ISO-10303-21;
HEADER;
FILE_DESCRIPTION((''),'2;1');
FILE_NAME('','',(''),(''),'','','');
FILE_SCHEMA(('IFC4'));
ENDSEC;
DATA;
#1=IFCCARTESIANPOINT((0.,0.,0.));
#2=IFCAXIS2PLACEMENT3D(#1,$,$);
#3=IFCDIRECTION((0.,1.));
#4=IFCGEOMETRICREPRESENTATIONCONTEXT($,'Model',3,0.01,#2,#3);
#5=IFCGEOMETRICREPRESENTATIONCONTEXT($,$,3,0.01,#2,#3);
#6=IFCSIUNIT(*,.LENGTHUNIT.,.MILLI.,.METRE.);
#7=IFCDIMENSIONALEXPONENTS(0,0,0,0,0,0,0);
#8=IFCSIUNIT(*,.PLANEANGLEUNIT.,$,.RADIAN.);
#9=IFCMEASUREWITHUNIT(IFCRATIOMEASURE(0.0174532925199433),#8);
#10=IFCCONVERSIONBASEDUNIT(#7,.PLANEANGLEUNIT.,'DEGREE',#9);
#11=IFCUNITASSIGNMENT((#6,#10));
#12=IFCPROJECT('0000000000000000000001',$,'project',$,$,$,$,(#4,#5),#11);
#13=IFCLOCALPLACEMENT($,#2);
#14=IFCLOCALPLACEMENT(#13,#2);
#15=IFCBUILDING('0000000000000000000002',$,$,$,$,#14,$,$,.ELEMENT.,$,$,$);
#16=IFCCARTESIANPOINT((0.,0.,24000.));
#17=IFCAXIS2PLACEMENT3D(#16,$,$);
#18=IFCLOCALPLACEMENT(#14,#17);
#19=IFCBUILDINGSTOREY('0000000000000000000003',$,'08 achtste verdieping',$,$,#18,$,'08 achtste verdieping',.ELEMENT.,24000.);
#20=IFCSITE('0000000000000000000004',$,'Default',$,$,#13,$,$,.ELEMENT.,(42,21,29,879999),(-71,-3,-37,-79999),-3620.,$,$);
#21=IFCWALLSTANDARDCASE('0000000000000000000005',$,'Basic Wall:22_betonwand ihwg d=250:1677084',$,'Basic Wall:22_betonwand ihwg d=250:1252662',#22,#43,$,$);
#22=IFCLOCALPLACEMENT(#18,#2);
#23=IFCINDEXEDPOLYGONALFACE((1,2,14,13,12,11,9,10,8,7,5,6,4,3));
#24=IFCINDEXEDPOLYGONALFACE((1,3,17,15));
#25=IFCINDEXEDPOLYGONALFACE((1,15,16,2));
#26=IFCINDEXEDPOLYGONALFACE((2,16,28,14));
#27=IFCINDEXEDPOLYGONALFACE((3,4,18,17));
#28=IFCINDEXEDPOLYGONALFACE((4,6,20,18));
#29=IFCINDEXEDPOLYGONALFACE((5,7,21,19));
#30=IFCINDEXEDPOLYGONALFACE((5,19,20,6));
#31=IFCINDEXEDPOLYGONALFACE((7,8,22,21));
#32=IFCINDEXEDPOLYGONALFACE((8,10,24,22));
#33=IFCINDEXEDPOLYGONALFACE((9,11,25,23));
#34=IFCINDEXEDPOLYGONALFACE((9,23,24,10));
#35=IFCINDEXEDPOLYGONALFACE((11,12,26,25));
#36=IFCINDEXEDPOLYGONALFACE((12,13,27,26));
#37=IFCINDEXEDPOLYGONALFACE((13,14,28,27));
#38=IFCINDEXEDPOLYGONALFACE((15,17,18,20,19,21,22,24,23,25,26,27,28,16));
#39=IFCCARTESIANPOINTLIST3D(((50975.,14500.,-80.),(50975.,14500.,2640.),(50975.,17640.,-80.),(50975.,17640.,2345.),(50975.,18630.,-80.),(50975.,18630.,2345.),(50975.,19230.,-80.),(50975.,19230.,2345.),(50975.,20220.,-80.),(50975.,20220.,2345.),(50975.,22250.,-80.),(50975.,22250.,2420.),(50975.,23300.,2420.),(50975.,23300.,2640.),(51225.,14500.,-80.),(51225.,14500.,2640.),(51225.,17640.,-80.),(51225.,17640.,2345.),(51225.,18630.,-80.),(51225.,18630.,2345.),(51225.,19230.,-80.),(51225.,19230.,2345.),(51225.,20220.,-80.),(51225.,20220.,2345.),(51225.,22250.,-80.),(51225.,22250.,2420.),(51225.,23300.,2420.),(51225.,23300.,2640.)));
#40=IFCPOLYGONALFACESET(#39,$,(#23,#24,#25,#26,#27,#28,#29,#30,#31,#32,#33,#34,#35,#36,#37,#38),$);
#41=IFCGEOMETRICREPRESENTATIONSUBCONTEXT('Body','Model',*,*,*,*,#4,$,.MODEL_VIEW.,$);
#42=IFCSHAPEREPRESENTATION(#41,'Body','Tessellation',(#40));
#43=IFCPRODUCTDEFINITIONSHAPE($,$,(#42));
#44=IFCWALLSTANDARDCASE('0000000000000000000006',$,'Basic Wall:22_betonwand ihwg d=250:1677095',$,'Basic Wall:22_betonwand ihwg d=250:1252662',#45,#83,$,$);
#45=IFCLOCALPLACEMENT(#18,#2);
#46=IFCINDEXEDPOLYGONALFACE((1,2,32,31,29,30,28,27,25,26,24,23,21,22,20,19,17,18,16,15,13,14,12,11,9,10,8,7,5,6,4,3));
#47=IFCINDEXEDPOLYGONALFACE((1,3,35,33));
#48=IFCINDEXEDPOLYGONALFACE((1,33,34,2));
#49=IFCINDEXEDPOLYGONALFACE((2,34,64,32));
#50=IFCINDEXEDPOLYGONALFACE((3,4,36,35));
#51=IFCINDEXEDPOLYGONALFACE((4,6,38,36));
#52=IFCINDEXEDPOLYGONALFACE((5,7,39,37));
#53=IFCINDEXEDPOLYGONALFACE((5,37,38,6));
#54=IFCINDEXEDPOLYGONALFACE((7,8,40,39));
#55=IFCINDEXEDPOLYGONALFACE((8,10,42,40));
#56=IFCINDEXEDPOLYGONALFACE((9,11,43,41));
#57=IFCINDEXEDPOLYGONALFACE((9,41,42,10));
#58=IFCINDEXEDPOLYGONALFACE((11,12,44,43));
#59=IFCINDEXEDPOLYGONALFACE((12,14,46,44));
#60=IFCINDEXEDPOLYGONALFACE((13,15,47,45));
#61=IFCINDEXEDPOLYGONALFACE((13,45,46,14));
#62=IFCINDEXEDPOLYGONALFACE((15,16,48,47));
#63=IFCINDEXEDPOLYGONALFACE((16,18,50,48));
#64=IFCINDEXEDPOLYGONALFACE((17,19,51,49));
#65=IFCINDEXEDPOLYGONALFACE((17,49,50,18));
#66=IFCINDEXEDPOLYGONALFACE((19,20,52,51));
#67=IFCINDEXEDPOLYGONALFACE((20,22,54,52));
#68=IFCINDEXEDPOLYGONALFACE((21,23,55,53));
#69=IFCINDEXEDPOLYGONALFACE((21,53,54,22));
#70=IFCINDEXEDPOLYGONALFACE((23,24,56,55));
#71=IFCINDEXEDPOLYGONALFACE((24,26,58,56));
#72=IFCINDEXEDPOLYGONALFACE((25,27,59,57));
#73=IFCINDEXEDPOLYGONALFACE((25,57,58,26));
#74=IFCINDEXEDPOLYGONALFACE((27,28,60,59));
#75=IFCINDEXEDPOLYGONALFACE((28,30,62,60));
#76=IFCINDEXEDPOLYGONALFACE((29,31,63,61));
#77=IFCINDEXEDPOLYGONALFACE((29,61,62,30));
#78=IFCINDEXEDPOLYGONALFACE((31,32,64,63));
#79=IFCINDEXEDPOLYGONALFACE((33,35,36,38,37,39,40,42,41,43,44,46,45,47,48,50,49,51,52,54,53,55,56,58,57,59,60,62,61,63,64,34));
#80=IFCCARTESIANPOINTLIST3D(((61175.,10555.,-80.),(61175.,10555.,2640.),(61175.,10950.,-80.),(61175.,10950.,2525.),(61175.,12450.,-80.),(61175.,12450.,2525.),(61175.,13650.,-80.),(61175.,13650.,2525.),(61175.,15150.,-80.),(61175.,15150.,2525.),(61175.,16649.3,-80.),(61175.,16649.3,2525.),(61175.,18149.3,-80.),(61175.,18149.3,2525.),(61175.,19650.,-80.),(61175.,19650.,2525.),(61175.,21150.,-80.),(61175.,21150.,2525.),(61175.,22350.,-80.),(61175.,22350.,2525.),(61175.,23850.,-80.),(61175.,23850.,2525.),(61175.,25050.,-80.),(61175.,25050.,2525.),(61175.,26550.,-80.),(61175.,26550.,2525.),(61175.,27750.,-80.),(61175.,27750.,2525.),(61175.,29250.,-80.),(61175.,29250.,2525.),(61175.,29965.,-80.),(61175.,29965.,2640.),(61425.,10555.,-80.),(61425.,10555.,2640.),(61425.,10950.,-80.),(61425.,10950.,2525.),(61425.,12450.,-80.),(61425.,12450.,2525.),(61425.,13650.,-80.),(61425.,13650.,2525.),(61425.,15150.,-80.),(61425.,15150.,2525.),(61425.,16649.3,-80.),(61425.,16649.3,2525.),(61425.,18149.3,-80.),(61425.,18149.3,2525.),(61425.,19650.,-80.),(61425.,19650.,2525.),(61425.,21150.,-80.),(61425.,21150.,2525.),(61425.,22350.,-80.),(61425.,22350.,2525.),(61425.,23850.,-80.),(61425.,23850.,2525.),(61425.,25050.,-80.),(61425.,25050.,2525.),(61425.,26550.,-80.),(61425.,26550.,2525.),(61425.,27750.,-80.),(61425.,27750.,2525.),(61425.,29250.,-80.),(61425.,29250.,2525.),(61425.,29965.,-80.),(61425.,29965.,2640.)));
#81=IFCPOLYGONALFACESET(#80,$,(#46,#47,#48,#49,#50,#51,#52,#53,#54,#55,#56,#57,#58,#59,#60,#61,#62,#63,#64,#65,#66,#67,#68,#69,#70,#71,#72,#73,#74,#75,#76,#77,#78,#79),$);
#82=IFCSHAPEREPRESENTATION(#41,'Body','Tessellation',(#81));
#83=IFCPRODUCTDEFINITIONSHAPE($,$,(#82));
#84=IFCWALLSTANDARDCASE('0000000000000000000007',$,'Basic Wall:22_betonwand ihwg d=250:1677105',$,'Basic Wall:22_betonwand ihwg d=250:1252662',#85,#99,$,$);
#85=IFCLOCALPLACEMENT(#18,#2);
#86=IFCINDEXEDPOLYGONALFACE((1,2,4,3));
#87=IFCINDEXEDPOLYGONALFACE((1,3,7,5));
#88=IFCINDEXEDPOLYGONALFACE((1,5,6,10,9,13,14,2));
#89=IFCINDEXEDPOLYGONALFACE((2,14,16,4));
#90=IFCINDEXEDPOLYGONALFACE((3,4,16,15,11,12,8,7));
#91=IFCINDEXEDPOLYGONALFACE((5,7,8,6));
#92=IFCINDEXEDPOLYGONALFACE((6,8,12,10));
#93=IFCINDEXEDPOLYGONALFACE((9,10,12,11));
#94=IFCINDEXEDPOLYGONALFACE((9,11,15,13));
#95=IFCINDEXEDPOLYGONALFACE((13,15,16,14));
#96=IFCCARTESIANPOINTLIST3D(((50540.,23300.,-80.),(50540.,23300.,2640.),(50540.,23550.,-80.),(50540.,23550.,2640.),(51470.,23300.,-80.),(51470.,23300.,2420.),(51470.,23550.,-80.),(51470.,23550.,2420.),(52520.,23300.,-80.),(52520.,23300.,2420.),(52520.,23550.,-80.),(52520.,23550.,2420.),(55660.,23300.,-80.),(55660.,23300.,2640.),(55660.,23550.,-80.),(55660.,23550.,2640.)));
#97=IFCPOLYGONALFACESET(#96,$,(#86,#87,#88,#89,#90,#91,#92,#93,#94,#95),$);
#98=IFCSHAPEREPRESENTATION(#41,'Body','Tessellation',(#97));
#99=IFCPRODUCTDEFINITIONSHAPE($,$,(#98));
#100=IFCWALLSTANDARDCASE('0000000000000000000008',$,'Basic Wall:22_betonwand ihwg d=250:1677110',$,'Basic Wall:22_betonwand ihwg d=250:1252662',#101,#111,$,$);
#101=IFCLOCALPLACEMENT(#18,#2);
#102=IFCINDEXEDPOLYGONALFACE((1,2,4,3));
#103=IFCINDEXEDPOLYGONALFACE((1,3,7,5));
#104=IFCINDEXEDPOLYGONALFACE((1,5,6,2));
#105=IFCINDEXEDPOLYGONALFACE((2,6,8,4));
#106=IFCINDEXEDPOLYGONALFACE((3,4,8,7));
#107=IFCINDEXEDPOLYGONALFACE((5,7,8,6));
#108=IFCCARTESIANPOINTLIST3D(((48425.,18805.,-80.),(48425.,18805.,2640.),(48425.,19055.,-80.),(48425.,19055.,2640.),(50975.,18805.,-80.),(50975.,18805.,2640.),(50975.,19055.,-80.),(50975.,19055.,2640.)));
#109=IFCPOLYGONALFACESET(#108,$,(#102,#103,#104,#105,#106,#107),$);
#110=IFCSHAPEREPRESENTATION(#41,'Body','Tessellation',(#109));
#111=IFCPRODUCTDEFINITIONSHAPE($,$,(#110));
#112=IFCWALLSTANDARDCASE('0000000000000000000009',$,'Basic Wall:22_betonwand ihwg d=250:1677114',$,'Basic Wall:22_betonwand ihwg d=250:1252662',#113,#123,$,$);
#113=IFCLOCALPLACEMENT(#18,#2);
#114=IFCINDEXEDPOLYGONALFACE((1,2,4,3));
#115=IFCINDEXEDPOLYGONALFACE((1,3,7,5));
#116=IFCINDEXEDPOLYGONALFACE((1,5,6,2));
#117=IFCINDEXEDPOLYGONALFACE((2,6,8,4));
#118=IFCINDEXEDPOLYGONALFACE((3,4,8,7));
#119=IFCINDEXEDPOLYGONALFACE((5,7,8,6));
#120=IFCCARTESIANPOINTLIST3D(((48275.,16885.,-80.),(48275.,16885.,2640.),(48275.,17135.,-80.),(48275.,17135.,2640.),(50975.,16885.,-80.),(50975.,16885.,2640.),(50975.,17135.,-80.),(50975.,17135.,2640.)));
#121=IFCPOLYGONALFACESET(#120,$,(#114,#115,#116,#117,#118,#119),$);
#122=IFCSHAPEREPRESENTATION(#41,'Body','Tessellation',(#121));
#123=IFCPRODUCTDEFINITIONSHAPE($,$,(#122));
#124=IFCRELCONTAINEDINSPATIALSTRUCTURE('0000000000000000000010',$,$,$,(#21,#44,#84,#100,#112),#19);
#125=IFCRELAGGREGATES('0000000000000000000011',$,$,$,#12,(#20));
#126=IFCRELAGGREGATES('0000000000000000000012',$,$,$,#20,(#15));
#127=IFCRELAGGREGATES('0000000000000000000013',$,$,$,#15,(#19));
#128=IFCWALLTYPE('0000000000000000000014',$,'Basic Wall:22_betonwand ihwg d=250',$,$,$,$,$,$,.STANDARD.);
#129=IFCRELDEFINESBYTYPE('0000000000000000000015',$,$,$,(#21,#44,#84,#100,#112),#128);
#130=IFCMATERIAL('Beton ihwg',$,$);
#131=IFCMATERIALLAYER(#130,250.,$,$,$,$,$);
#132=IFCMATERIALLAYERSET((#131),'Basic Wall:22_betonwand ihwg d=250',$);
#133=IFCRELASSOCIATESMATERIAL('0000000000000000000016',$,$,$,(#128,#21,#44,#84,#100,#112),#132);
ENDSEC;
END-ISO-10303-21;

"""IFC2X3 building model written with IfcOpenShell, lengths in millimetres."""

from ifc_helpers import new_model, entity, si_unit, converted_unit, direction, frame, frame_2d, origin, place, context, subcontext, project, spatial, rectangle, extrude, material, layer, layer_set, layer_usage, type_object, element, save


model = new_model("IFC2X3")

# Units and contexts
model_context = context("Model", 3, precision=0.01, world=origin(), true_north=direction((0.0, 1.0)))
context_of_model = context(None, 3, precision=0.01, world=origin(), true_north=direction((0.0, 1.0)))
body_context = subcontext(model_context, "Body", "Model", "MODEL_VIEW")
ifc_project = project(units=[si_unit("LENGTHUNIT", "METRE", prefix="MILLI"), converted_unit("PLANEANGLEUNIT", "DEGREE", entity("IfcRatioMeasure", 0.0174532925199433), si_unit("PLANEANGLEUNIT", "RADIAN"), dimensions=[0, 0, 0, 0, 0, 0, 0])], contexts=[model_context, context_of_model])

# Site, building, storey
site_placement = place(None, origin())
site = spatial("IfcSite", under=ifc_project, at=site_placement, Name="Default", CompositionType="ELEMENT", RefLatitude=(42, 21, 29, 879999), RefLongitude=(-71, -3, -37, -79999), RefElevation=-3620.0)
building_placement = place(site_placement, origin())
building = spatial("IfcBuilding", under=site, at=building_placement, CompositionType="ELEMENT")
storey_placement = place(building_placement, frame((0.0, 0.0, 24000.0)))
storey = spatial("IfcBuildingStorey", under=building, at=storey_placement, Name="08 achtste verdieping", LongName="08 achtste verdieping", CompositionType="ELEMENT", Elevation=24000.0)

# Walls, openings
ifc_material_1 = material(Name="Beton ihwg")
ifc_layer_1 = layer(ifc_material_1, 250.0)
ifc_layer_set_1 = layer_set([ifc_layer_1], Name="Basic Wall:22_betonwand ihwg d=250")
ifc_layer_usage_1 = layer_usage(ifc_layer_set_1, "AXIS2", "NEGATIVE", 125.0)
wall_type_1 = type_object("IfcWallType", Name="Basic Wall:22_betonwand ihwg d=250", PredefinedType="STANDARD", material=ifc_layer_set_1)
wall_1_placement = place(storey_placement, frame((51100.0, 23300.0, -80.0), z_axis=(0.0, 0.0, 1.0), x_axis=(0.0, -1.0, 0.0)))
wall_1 = element("IfcWallStandardCase", 1, at=wall_1_placement, inside=storey, type_object=wall_type_1, material=ifc_layer_usage_1, Name="Basic Wall:22_betonwand ihwg d=250:1677084", ObjectType="Basic Wall:22_betonwand ihwg d=250:1252662", context=body_context, shape_type="SweptSolid", body=[
    extrude(rectangle(XDim=8800.0, YDim=250.0, at=frame_2d((4400.0, 0.0), x_axis=(-1.0, 0.0))), origin(), (0.0, 0.0, 1.0), 2720.0),
])
opening_1_placement = place(wall_1_placement, frame((23300.0, -51100.0, 80.0), z_axis=(0.0, 0.0, 1.0), x_axis=(0.0, 1.0, 0.0)))
element("IfcOpeningElement", 2, at=opening_1_placement, cuts=wall_1, ObjectType="Opening", context=body_context, shape_type="SweptSolid", body=[
    extrude(rectangle(XDim=2425.0, YDim=990.0, at=frame_2d((0.0, 0.0), x_axis=(1.0, 0.0))), frame((50700.0, 19725.0, 1132.5), z_axis=(1.0, 0.0, 0.0), x_axis=(0.0, 0.0, -1.0)), (0.0, 0.0, 1.0), 800.0),
])
opening_2_placement = place(wall_1_placement, frame((23300.0, -51100.0, 80.0), z_axis=(0.0, 0.0, 1.0), x_axis=(0.0, 1.0, 0.0)))
element("IfcOpeningElement", 3, at=opening_2_placement, cuts=wall_1, ObjectType="Opening", context=body_context, shape_type="SweptSolid", body=[
    extrude(rectangle(XDim=2425.0, YDim=990.0, at=frame_2d((0.0, 0.0), x_axis=(1.0, 0.0))), frame((50700.0, 18135.0, 1132.5), z_axis=(1.0, 0.0, 0.0), x_axis=(0.0, 0.0, -1.0)), (0.0, 0.0, 1.0), 800.0),
])
opening_3_placement = place(wall_1_placement, frame((23300.0, -51100.0, 80.0), z_axis=(0.0, 0.0, 1.0), x_axis=(0.0, 1.0, 0.0)))
element("IfcOpeningElement", 4, at=opening_3_placement, cuts=wall_1, ObjectType="Opening", context=body_context, shape_type="SweptSolid", body=[
    extrude(rectangle(XDim=2500.0, YDim=1050.0, at=frame_2d((0.0, 0.0), x_axis=(1.0, 0.0))), frame((50700.0, 22775.0, 1170.0), z_axis=(1.0, 0.0, 0.0), x_axis=(0.0, 0.0, -1.0)), (0.0, 0.0, 1.0), 800.0),
])
ifc_layer_usage_2 = layer_usage(ifc_layer_set_1, "AXIS2", "POSITIVE", -125.0)
wall_2_placement = place(storey_placement, frame((61300.0, 29965.0, -80.0), z_axis=(0.0, 0.0, 1.0), x_axis=(0.0, -1.0, 0.0)))
wall_2 = element("IfcWallStandardCase", 5, at=wall_2_placement, inside=storey, type_object=wall_type_1, material=ifc_layer_usage_2, Name="Basic Wall:22_betonwand ihwg d=250:1677095", ObjectType="Basic Wall:22_betonwand ihwg d=250:1252662", context=body_context, shape_type="SweptSolid", body=[
    extrude(rectangle(XDim=19410.0, YDim=250.0, at=frame_2d((9705.0, 0.0), x_axis=(-1.0, 0.0))), origin(), (0.0, 0.0, 1.0), 2720.0),
])
opening_4_placement = place(wall_2_placement, frame((29965.0, -61300.0, 80.0), z_axis=(0.0, 0.0, 1.0), x_axis=(0.0, 1.0, 0.0)))
element("IfcOpeningElement", 6, at=opening_4_placement, cuts=wall_2, ObjectType="Opening", context=body_context, shape_type="SweptSolid", body=[
    extrude(rectangle(XDim=2605.0, YDim=1500.0, at=frame_2d((0.0, 0.0), x_axis=(1.0, 0.0))), frame((59901.0, 28500.0, 1222.5), z_axis=(1.0, 0.0, 0.0), x_axis=(0.0, 0.0, -1.0)), (0.0, 0.0, 1.0), 3048.0),
])
opening_5_placement = place(wall_2_placement, frame((29965.0, -61300.0, 80.0), z_axis=(0.0, 0.0, 1.0), x_axis=(0.0, 1.0, 0.0)))
element("IfcOpeningElement", 7, at=opening_5_placement, cuts=wall_2, ObjectType="Opening", context=body_context, shape_type="SweptSolid", body=[
    extrude(rectangle(XDim=2605.0, YDim=1500.0, at=frame_2d((0.0, 0.0), x_axis=(1.0, 0.0))), frame((59901.0, 25800.0, 1222.5), z_axis=(1.0, 0.0, 0.0), x_axis=(0.0, 0.0, -1.0)), (0.0, 0.0, 1.0), 3048.0),
])
opening_6_placement = place(wall_2_placement, frame((29965.0, -61300.0, 80.0), z_axis=(0.0, 0.0, 1.0), x_axis=(0.0, 1.0, 0.0)))
element("IfcOpeningElement", 8, at=opening_6_placement, cuts=wall_2, ObjectType="Opening", context=body_context, shape_type="SweptSolid", body=[
    extrude(rectangle(XDim=2605.0, YDim=1500.0, at=frame_2d((0.0, 0.0), x_axis=(1.0, 0.0))), frame((59901.0, 23100.0, 1222.5), z_axis=(1.0, 0.0, 0.0), x_axis=(0.0, 0.0, -1.0)), (0.0, 0.0, 1.0), 3048.0),
])
opening_7_placement = place(wall_2_placement, frame((29965.0, -61300.0, 80.0), z_axis=(0.0, 0.0, 1.0), x_axis=(0.0, 1.0, 0.0)))
element("IfcOpeningElement", 9, at=opening_7_placement, cuts=wall_2, ObjectType="Opening", context=body_context, shape_type="SweptSolid", body=[
    extrude(rectangle(XDim=2605.0, YDim=1500.0, at=frame_2d((0.0, 0.0), x_axis=(1.0, 0.0))), frame((59901.0, 17399.3, 1222.5), z_axis=(1.0, 0.0, 0.0), x_axis=(0.0, 0.0, -1.0)), (0.0, 0.0, 1.0), 3048.0),
])
opening_8_placement = place(wall_2_placement, frame((29965.0, -61300.0, 80.0), z_axis=(0.0, 0.0, 1.0), x_axis=(0.0, 1.0, 0.0)))
element("IfcOpeningElement", 10, at=opening_8_placement, cuts=wall_2, ObjectType="Opening", context=body_context, shape_type="SweptSolid", body=[
    extrude(rectangle(XDim=2605.0, YDim=1500.0, at=frame_2d((0.0, 0.0), x_axis=(1.0, 0.0))), frame((59901.0, 14400.0, 1222.5), z_axis=(1.0, 0.0, 0.0), x_axis=(0.0, 0.0, -1.0)), (0.0, 0.0, 1.0), 3048.0),
])
opening_9_placement = place(wall_2_placement, frame((29965.0, -61300.0, 80.0), z_axis=(0.0, 0.0, 1.0), x_axis=(0.0, 1.0, 0.0)))
element("IfcOpeningElement", 11, at=opening_9_placement, cuts=wall_2, ObjectType="Opening", context=body_context, shape_type="SweptSolid", body=[
    extrude(rectangle(XDim=2605.0, YDim=1500.0, at=frame_2d((0.0, 0.0), x_axis=(1.0, 0.0))), frame((59901.0, 20400.0, 1222.5), z_axis=(1.0, 0.0, 0.0), x_axis=(0.0, 0.0, -1.0)), (0.0, 0.0, 1.0), 3048.0),
])
opening_10_placement = place(wall_2_placement, frame((29965.0, -61300.0, 80.0), z_axis=(0.0, 0.0, 1.0), x_axis=(0.0, 1.0, 0.0)))
element("IfcOpeningElement", 12, at=opening_10_placement, cuts=wall_2, ObjectType="Opening", context=body_context, shape_type="SweptSolid", body=[
    extrude(rectangle(XDim=2605.0, YDim=1500.0, at=frame_2d((0.0, 0.0), x_axis=(1.0, 0.0))), frame((59901.0, 11700.0, 1222.5), z_axis=(1.0, 0.0, 0.0), x_axis=(0.0, 0.0, -1.0)), (0.0, 0.0, 1.0), 3048.0),
])
ifc_layer_usage_3 = layer_usage(ifc_layer_set_1, "AXIS2", "POSITIVE", -125.0)
wall_3_placement = place(storey_placement, frame((55660.0, 23425.0, -80.0), z_axis=(0.0, 0.0, 1.0), x_axis=(-1.0, 0.0, 0.0)))
wall_3 = element("IfcWallStandardCase", 13, at=wall_3_placement, inside=storey, type_object=wall_type_1, material=ifc_layer_usage_3, Name="Basic Wall:22_betonwand ihwg d=250:1677105", ObjectType="Basic Wall:22_betonwand ihwg d=250:1252662", context=body_context, shape_type="SweptSolid", body=[
    extrude(rectangle(XDim=5120.0, YDim=250.0, at=frame_2d((2560.0, 0.0), x_axis=(-1.0, 0.0))), origin(), (0.0, 0.0, 1.0), 2720.0),
])
opening_11_placement = place(wall_3_placement, origin())
element("IfcOpeningElement", 14, at=opening_11_placement, cuts=wall_3, ObjectType="Opening", context=body_context, shape_type="SweptSolid", body=[
    extrude(rectangle(XDim=2500.0, YDim=800.0, at=frame_2d((0.0, 0.0), x_axis=(0.0, 1.0))), frame((2735.0, 125.0, 1250.0), z_axis=(0.0, 1.0, 0.0), x_axis=(1.0, 0.0, 0.0)), (0.0, 0.0, 1.0), 1034.0),
])
opening_12_placement = place(wall_3_placement, origin())
element("IfcOpeningElement", 15, at=opening_12_placement, cuts=wall_3, ObjectType="Opening", context=body_context, shape_type="SweptSolid", body=[
    extrude(rectangle(XDim=2500.0, YDim=800.0, at=frame_2d((0.0, 0.0), x_axis=(0.0, 1.0))), frame((4560.0, 125.0, 1250.0), z_axis=(0.0, 1.0, 0.0), x_axis=(1.0, 0.0, 0.0)), (0.0, 0.0, 1.0), 1050.0),
])
opening_13_placement = place(wall_3_placement, frame((55660.0, 23425.0, 80.0), z_axis=(0.0, 0.0, 1.0), x_axis=(-1.0, 0.0, 0.0)))
element("IfcOpeningElement", 16, at=opening_13_placement, cuts=wall_3, ObjectType="Opening", context=body_context, shape_type="SweptSolid", body=[
    extrude(rectangle(XDim=2500.0, YDim=1050.0, at=frame_2d((0.0, 0.0), x_axis=(0.0, 1.0))), frame((51995.0, 23825.0, 1170.0), z_axis=(0.0, -1.0, 0.0), x_axis=(-1.0, 0.0, 0.0)), (0.0, 0.0, 1.0), 800.0),
])

# Walls
ifc_layer_usage_4 = layer_usage(ifc_layer_set_1, "AXIS2", "POSITIVE", -125.0)
wall_4_placement = place(storey_placement, frame((50975.0, 18930.0, -80.0), z_axis=(0.0, 0.0, 1.0), x_axis=(-1.0, 0.0, 0.0)))
element("IfcWallStandardCase", 17, at=wall_4_placement, inside=storey, type_object=wall_type_1, material=ifc_layer_usage_4, Name="Basic Wall:22_betonwand ihwg d=250:1677110", ObjectType="Basic Wall:22_betonwand ihwg d=250:1252662", context=body_context, shape_type="SweptSolid", body=[
    extrude(rectangle(XDim=2550.0, YDim=250.0, at=frame_2d((1275.0, 0.0), x_axis=(-1.0, 0.0))), origin(), (0.0, 0.0, 1.0), 2720.0),
])
ifc_layer_usage_5 = layer_usage(ifc_layer_set_1, "AXIS2", "POSITIVE", -125.0)
wall_5_placement = place(storey_placement, frame((50975.0, 17010.0, -80.0), z_axis=(0.0, 0.0, 1.0), x_axis=(-1.0, 0.0, 0.0)))
element("IfcWallStandardCase", 18, at=wall_5_placement, inside=storey, type_object=wall_type_1, material=ifc_layer_usage_5, Name="Basic Wall:22_betonwand ihwg d=250:1677114", ObjectType="Basic Wall:22_betonwand ihwg d=250:1252662", context=body_context, shape_type="SweptSolid", body=[
    extrude(rectangle(XDim=2700.0, YDim=250.0, at=frame_2d((1350.0, 0.0), x_axis=(-1.0, 0.0))), origin(), (0.0, 0.0, 1.0), 2720.0),
])

save(model, "model.ifc")
